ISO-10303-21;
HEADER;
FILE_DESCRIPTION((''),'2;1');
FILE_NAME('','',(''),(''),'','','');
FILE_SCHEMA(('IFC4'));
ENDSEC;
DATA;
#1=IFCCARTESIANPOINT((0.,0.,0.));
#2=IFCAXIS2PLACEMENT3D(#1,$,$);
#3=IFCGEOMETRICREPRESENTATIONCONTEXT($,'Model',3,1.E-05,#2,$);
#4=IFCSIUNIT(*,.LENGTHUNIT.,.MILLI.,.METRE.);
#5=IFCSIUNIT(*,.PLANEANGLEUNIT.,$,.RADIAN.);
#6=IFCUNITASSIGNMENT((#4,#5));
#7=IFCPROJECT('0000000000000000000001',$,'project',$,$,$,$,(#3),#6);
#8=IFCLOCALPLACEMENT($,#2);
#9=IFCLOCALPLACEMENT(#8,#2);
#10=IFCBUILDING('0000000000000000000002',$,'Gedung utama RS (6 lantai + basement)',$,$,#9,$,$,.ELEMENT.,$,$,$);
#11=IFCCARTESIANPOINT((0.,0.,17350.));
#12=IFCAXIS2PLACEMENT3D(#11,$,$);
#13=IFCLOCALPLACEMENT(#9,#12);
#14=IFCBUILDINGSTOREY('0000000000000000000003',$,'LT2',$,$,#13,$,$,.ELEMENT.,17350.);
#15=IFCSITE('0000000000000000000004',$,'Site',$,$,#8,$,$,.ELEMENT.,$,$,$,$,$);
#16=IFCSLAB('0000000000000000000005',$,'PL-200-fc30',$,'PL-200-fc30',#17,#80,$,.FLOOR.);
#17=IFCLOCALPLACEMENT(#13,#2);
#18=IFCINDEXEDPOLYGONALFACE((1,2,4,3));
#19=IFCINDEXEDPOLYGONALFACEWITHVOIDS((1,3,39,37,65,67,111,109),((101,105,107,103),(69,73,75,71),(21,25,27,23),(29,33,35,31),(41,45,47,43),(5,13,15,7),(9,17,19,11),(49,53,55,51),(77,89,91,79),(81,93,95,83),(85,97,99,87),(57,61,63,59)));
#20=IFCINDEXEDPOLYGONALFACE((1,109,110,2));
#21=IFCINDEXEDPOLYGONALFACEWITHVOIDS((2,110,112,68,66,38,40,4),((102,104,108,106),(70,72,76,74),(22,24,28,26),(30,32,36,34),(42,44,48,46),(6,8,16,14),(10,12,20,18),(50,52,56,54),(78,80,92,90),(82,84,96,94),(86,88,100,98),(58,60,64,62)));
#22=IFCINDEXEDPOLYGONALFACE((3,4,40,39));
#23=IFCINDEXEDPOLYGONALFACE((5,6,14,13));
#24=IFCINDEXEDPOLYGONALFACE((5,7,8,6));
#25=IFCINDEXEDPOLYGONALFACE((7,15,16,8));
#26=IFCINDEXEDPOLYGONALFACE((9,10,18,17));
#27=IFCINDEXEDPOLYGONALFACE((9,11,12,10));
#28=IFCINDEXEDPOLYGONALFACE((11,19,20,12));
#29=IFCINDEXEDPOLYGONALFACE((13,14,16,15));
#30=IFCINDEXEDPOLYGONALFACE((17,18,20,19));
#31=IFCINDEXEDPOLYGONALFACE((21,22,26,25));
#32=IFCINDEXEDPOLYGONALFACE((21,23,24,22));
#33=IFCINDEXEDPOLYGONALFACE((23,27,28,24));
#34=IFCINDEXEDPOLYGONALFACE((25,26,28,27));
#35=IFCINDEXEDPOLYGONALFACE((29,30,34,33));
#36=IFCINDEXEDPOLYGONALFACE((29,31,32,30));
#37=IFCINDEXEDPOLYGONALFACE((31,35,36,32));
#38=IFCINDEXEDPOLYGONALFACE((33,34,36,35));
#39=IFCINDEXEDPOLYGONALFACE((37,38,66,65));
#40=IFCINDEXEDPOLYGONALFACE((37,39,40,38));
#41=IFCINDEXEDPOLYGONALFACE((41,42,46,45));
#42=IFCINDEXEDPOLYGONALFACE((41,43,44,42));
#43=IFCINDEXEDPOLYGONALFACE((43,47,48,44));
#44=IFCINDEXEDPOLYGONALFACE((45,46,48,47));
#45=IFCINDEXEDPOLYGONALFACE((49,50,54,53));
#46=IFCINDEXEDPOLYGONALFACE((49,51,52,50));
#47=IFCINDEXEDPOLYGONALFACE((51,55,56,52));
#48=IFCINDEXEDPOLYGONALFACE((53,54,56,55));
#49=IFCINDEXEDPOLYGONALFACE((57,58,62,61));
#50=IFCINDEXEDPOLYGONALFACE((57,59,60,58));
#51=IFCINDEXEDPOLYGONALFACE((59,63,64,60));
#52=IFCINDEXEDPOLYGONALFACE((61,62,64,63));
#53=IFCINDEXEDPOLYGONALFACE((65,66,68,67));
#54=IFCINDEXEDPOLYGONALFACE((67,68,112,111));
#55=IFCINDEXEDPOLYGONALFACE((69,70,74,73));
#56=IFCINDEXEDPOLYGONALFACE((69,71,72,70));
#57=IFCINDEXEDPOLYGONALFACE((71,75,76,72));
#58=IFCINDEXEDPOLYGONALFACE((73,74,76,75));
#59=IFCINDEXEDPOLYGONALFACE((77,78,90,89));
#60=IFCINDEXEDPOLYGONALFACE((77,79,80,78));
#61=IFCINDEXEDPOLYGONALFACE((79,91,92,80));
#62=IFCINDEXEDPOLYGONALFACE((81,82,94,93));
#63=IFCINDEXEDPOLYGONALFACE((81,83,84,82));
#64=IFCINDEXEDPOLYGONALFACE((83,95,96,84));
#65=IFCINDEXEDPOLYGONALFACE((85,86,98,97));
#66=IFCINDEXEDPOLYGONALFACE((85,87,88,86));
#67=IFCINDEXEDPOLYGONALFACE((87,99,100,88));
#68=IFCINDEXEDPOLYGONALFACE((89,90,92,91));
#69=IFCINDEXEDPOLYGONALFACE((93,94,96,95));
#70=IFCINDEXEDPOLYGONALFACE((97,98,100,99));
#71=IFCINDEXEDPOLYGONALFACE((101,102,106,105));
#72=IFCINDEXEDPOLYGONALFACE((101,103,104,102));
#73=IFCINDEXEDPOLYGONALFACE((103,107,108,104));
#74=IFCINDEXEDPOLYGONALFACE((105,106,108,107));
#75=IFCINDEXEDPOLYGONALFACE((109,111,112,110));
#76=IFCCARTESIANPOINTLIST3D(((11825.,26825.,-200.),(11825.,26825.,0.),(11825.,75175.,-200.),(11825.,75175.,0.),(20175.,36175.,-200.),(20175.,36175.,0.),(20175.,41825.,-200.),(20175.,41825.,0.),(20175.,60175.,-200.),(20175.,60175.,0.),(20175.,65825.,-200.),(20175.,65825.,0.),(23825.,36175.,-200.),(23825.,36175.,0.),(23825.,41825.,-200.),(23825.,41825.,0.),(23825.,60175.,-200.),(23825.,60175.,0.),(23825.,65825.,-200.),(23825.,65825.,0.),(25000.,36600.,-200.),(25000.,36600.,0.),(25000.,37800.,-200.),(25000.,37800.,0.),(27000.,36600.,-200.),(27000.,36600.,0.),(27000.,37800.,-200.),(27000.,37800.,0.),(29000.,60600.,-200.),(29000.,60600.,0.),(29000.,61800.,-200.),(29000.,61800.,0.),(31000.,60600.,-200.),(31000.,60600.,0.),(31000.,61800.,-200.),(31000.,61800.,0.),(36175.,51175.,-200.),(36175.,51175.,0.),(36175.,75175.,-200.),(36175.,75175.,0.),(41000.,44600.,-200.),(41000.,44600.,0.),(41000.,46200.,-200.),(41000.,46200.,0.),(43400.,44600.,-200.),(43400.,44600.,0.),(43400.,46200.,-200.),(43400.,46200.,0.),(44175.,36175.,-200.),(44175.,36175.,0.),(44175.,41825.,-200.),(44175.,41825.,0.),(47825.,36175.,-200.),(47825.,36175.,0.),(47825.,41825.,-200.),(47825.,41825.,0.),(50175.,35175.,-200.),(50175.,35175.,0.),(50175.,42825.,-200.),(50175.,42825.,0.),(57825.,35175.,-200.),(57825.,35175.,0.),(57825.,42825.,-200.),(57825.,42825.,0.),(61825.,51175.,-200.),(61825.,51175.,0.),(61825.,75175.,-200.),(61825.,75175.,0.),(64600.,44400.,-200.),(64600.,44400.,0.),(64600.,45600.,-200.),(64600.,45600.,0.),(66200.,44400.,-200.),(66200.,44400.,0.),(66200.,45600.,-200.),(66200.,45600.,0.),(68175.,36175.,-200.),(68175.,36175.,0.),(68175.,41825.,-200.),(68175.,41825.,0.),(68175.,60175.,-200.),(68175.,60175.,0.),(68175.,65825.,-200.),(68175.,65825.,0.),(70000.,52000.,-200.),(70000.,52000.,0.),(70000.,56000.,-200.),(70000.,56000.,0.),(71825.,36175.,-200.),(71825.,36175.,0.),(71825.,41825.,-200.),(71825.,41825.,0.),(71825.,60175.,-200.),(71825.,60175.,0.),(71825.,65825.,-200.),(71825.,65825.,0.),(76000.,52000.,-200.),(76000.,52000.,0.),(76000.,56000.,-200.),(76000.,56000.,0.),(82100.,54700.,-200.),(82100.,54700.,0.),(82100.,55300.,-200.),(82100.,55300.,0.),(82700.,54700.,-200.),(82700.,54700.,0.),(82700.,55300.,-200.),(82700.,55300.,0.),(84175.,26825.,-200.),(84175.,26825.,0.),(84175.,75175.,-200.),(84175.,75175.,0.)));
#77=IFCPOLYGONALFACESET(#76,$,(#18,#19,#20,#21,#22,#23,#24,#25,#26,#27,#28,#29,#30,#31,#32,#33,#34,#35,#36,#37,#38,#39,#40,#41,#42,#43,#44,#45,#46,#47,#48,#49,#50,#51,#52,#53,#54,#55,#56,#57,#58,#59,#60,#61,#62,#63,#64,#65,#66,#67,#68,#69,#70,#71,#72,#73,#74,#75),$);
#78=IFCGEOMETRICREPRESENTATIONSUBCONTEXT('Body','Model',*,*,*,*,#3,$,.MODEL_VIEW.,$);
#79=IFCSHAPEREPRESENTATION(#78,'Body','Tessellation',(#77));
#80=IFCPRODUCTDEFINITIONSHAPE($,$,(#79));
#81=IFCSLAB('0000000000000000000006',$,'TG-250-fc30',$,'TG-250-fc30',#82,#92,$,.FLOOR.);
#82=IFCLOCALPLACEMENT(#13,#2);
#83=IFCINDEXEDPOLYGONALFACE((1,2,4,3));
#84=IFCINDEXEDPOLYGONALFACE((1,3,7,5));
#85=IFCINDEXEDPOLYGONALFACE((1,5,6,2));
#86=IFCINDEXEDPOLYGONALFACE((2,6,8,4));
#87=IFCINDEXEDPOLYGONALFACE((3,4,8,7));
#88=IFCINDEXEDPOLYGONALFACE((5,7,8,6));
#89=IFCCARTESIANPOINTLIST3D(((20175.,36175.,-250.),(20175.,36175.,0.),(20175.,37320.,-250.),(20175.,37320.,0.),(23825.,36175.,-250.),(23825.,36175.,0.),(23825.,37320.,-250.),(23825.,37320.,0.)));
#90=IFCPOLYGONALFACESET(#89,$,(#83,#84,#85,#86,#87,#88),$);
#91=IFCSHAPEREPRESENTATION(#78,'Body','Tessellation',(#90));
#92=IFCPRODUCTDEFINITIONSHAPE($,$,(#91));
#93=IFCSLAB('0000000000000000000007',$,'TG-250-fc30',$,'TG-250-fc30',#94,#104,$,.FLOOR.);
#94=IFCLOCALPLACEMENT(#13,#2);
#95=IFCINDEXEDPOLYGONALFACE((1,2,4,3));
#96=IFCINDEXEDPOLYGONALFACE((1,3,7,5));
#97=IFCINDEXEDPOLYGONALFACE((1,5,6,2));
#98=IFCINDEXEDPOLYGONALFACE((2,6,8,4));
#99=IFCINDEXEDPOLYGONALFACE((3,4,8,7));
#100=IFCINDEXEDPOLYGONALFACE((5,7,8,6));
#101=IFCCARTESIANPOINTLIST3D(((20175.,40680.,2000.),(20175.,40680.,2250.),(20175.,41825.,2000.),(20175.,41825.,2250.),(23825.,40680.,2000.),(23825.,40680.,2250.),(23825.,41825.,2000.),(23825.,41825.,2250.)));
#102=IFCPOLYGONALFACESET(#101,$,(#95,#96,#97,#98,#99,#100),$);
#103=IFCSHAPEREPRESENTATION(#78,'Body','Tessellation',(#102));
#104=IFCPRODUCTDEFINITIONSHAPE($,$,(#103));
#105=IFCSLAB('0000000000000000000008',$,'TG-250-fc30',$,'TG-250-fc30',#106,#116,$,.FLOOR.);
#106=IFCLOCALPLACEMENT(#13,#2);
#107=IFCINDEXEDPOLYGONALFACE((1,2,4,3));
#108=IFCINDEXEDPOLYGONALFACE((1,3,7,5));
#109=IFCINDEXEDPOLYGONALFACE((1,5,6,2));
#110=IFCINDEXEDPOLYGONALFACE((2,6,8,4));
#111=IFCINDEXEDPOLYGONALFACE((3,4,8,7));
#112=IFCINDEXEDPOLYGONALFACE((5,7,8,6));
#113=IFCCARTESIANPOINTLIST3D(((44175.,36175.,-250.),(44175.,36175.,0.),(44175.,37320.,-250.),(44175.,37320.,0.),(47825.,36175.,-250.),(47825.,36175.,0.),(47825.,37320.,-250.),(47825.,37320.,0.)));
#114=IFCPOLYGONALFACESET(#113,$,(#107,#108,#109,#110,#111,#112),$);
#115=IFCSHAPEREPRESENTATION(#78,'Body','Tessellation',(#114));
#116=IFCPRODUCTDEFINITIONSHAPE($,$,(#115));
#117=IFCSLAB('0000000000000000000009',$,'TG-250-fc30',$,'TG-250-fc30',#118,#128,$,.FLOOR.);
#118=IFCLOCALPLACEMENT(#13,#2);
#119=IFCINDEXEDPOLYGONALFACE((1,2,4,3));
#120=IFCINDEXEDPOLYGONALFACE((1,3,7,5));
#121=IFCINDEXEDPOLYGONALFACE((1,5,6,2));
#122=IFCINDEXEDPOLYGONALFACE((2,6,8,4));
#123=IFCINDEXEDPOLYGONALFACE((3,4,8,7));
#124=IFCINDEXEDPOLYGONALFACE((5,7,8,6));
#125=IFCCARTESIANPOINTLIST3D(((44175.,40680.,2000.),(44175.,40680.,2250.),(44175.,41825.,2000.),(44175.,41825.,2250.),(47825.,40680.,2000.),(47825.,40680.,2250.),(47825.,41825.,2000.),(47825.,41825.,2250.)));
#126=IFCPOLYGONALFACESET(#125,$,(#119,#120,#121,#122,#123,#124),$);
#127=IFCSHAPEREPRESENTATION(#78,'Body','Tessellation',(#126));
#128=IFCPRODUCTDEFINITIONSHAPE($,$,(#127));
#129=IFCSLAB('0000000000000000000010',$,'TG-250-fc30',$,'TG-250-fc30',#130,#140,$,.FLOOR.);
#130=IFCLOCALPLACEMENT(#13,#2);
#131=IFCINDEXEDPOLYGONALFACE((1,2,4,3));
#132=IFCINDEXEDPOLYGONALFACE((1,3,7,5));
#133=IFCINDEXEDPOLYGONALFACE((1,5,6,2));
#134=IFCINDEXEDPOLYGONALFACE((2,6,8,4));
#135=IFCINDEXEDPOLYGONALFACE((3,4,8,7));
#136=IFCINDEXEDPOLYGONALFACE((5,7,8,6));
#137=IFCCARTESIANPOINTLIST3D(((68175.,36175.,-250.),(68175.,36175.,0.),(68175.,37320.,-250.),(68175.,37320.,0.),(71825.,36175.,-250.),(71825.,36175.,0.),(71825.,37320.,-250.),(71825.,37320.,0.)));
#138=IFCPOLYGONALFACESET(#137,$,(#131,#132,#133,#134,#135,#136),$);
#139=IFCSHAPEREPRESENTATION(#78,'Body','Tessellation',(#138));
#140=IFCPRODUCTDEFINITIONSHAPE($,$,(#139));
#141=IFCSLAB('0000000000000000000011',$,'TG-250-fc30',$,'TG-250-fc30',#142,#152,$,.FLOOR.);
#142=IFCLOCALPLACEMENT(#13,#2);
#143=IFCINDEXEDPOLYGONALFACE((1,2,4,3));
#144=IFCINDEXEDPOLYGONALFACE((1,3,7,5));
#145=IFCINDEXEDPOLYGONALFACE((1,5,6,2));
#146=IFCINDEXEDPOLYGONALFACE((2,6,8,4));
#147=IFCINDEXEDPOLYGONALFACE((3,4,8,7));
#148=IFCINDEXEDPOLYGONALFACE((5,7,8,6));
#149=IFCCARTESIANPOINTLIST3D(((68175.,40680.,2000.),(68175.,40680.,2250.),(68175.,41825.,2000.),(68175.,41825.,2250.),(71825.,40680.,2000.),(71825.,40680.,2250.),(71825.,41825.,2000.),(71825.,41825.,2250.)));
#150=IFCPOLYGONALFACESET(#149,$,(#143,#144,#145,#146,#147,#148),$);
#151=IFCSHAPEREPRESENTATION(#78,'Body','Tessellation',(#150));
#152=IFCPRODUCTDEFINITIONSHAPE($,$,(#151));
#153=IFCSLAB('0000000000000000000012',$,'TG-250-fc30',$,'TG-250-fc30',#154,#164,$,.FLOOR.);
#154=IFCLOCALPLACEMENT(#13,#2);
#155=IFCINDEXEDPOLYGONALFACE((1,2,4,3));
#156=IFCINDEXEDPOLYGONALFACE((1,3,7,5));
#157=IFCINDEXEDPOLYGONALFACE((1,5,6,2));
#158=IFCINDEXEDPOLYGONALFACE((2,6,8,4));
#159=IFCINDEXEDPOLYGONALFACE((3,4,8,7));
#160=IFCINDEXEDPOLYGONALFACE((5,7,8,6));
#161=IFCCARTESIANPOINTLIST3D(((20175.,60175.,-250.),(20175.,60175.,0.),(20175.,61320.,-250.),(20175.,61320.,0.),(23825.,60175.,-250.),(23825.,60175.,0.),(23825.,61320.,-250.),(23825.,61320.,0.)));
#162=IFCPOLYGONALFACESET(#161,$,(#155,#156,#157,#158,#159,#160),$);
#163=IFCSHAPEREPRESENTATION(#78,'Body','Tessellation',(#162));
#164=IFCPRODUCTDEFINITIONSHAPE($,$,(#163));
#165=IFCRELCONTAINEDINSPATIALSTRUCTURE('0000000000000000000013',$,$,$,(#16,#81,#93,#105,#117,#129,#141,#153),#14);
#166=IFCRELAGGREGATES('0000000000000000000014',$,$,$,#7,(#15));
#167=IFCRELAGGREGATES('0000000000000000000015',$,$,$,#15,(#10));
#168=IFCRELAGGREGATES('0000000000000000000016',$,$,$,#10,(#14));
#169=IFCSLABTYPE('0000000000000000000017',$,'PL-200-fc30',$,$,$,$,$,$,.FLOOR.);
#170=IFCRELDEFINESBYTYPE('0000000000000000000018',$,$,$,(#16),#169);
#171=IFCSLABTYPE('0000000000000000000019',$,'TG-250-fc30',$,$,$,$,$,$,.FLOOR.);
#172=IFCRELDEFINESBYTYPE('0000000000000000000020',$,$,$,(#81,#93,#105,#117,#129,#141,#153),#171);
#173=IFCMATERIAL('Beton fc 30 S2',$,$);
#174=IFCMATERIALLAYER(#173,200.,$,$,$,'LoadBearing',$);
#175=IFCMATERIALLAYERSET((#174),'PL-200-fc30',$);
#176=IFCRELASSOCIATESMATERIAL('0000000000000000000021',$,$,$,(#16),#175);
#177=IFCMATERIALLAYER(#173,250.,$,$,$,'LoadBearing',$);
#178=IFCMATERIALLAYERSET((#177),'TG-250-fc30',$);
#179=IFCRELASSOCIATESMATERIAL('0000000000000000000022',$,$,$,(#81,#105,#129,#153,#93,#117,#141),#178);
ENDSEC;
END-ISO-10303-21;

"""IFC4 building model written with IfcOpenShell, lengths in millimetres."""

from ifc_helpers import new_model, si_unit, frame, origin, place, context, subcontext, project, spatial, polyline, outline, extrude, material, layer, layer_set, layer_usage, type_object, element, save


model = new_model("IFC4")

# Units and contexts
model_context = context("Model", 3, precision=1e-05, world=origin())
body_context = subcontext(model_context, "Body", "Model", "MODEL_VIEW")
ifc_project = project(units=[si_unit("LENGTHUNIT", "METRE", prefix="MILLI"), si_unit("PLANEANGLEUNIT", "RADIAN")], contexts=[model_context])

# Site, building, storey
site_placement = place(None, origin())
site = spatial("IfcSite", under=ifc_project, at=site_placement, Name="Site", CompositionType="ELEMENT")
building_placement = place(site_placement, origin())
building = spatial("IfcBuilding", under=site, at=building_placement, Name="Gedung utama RS (6 lantai + basement)", CompositionType="ELEMENT")
storey_placement = place(building_placement, frame((0.0, 0.0, 17350.0)))
storey = spatial("IfcBuildingStorey", under=building, at=storey_placement, Name="LT2", CompositionType="ELEMENT", Elevation=17350.0)

# Shared definitions
ifc_material_1 = material(Name="Beton fc 30 S2")

# Shared definitions
ifc_layer_1 = layer(ifc_material_1, 200.0, Category="LoadBearing")
ifc_layer_set_1 = layer_set([ifc_layer_1], Name="PL-200-fc30")
slab_type_1 = type_object("IfcSlabType", Name="PL-200-fc30", PredefinedType="FLOOR")

# Slab, openings
ifc_layer_usage_1 = layer_usage(ifc_layer_set_1, "AXIS3", "NEGATIVE", 0.0)
slab_1_placement = place(storey_placement, origin())
slab_1 = element("IfcSlab", 1, at=slab_1_placement, inside=storey, type_object=slab_type_1, material=ifc_layer_usage_1, Name="PL-200-fc30", ObjectType="PL-200-fc30", PredefinedType="FLOOR", context=body_context, shape_type="SweptSolid", body=[
    extrude(outline(polyline([(61825.0, 75175.0), (61825.0, 51175.0), (36175.0, 51175.0), (36175.0, 75175.0), (11825.0, 75175.0), (11825.0, 26825.0), (84175.0, 26825.0), (84175.0, 75175.0), (61825.0, 75175.0)]), holes=[polyline([(23825.0, 36175.0), (23825.0, 41825.0), (20175.0, 41825.0), (20175.0, 36175.0), (23825.0, 36175.0)]), polyline([(47825.0, 36175.0), (47825.0, 41825.0), (44175.0, 41825.0), (44175.0, 36175.0), (47825.0, 36175.0)]), polyline([(71825.0, 36175.0), (71825.0, 41825.0), (68175.0, 41825.0), (68175.0, 36175.0), (71825.0, 36175.0)]), polyline([(23825.0, 60175.0), (23825.0, 65825.0), (20175.0, 65825.0), (20175.0, 60175.0), (23825.0, 60175.0)]), polyline([(71825.0, 60175.0), (71825.0, 65825.0), (68175.0, 65825.0), (68175.0, 60175.0), (71825.0, 60175.0)]), polyline([(76000.0, 52000.0), (76000.0, 56000.0), (70000.0, 56000.0), (70000.0, 52000.0), (76000.0, 52000.0)])]), frame((0.0, 0.0, -200.0)), (0.0, 0.0, 1.0), 200.0),
])
opening_1_placement = place(slab_1_placement, frame((0.0, 0.0, -4400.0)))
element("IfcOpeningElement", 2, at=opening_1_placement, cuts=slab_1, PredefinedType="OPENING", context=body_context, shape_type="SweptSolid", body=[
    extrude(outline(polyline([(27000.0, 36600.0), (27000.0, 37800.0), (25000.0, 37800.0), (25000.0, 36600.0), (27000.0, 36600.0)])), origin(), (0.0, 0.0, 1.0), 25800.0),
])
opening_2_placement = place(slab_1_placement, frame((0.0, 0.0, -4400.0)))
element("IfcOpeningElement", 3, at=opening_2_placement, cuts=slab_1, PredefinedType="OPENING", context=body_context, shape_type="SweptSolid", body=[
    extrude(outline(polyline([(43400.0, 44600.0), (43400.0, 46200.0), (41000.0, 46200.0), (41000.0, 44600.0), (43400.0, 44600.0)])), origin(), (0.0, 0.0, 1.0), 25800.0),
])
opening_3_placement = place(slab_1_placement, frame((0.0, 0.0, -4400.0)))
element("IfcOpeningElement", 4, at=opening_3_placement, cuts=slab_1, PredefinedType="OPENING", context=body_context, shape_type="SweptSolid", body=[
    extrude(outline(polyline([(66200.0, 44400.0), (66200.0, 45600.0), (64600.0, 45600.0), (64600.0, 44400.0), (66200.0, 44400.0)])), origin(), (0.0, 0.0, 1.0), 25800.0),
])
opening_4_placement = place(slab_1_placement, frame((0.0, 0.0, -4400.0)))
element("IfcOpeningElement", 5, at=opening_4_placement, cuts=slab_1, PredefinedType="OPENING", context=body_context, shape_type="SweptSolid", body=[
    extrude(outline(polyline([(31000.0, 60600.0), (31000.0, 61800.0), (29000.0, 61800.0), (29000.0, 60600.0), (31000.0, 60600.0)])), origin(), (0.0, 0.0, 1.0), 13200.0),
])
opening_5_placement = place(slab_1_placement, frame((0.0, 0.0, -4400.0)))
element("IfcOpeningElement", 6, at=opening_5_placement, cuts=slab_1, PredefinedType="OPENING", context=body_context, shape_type="SweptSolid", body=[
    extrude(outline(polyline([(82700.0, 54700.0), (82700.0, 55300.0), (82100.0, 55300.0), (82100.0, 54700.0), (82700.0, 54700.0)])), origin(), (0.0, 0.0, 1.0), 9000.0),
])
opening_6_placement = place(slab_1_placement, frame((0.0, 0.0, -4400.0)))
element("IfcOpeningElement", 7, at=opening_6_placement, cuts=slab_1, PredefinedType="OPENING", context=body_context, shape_type="SweptSolid", body=[
    extrude(outline(polyline([(57825.0, 35175.0), (57825.0, 42825.0), (50175.0, 42825.0), (50175.0, 35175.0), (57825.0, 35175.0)])), origin(), (0.0, 0.0, 1.0), 21600.0),
])

# Slabs
ifc_layer_2 = layer(ifc_material_1, 250.0, Category="LoadBearing")
ifc_layer_set_2 = layer_set([ifc_layer_2], Name="TG-250-fc30")
ifc_layer_usage_2 = layer_usage(ifc_layer_set_2, "AXIS3", "NEGATIVE", 0.0)
slab_type_2 = type_object("IfcSlabType", Name="TG-250-fc30", PredefinedType="FLOOR")
slab_2_placement = place(storey_placement, origin())
element("IfcSlab", 8, at=slab_2_placement, inside=storey, type_object=slab_type_2, material=ifc_layer_usage_2, Name="TG-250-fc30", ObjectType="TG-250-fc30", PredefinedType="FLOOR", context=body_context, shape_type="SweptSolid", body=[
    extrude(outline(polyline([(23825.0, 36175.0), (23825.0, 37320.0), (20175.0, 37320.0), (20175.0, 36175.0), (23825.0, 36175.0)])), frame((0.0, 0.0, -250.0)), (0.0, 0.0, 1.0), 250.0),
])
ifc_layer_usage_3 = layer_usage(ifc_layer_set_2, "AXIS3", "NEGATIVE", 2250.0)
slab_3_placement = place(storey_placement, origin())
element("IfcSlab", 9, at=slab_3_placement, inside=storey, type_object=slab_type_2, material=ifc_layer_usage_3, Name="TG-250-fc30", ObjectType="TG-250-fc30", PredefinedType="FLOOR", context=body_context, shape_type="SweptSolid", body=[
    extrude(outline(polyline([(23825.0, 40680.0), (23825.0, 41825.0), (20175.0, 41825.0), (20175.0, 40680.0), (23825.0, 40680.0)])), frame((0.0, 0.0, 2000.0)), (0.0, 0.0, 1.0), 250.0),
])
slab_4_placement = place(storey_placement, origin())
element("IfcSlab", 10, at=slab_4_placement, inside=storey, type_object=slab_type_2, material=ifc_layer_usage_2, Name="TG-250-fc30", ObjectType="TG-250-fc30", PredefinedType="FLOOR", context=body_context, shape_type="SweptSolid", body=[
    extrude(outline(polyline([(47825.0, 36175.0), (47825.0, 37320.0), (44175.0, 37320.0), (44175.0, 36175.0), (47825.0, 36175.0)])), frame((0.0, 0.0, -250.0)), (0.0, 0.0, 1.0), 250.0),
])
slab_5_placement = place(storey_placement, origin())
element("IfcSlab", 11, at=slab_5_placement, inside=storey, type_object=slab_type_2, material=ifc_layer_usage_3, Name="TG-250-fc30", ObjectType="TG-250-fc30", PredefinedType="FLOOR", context=body_context, shape_type="SweptSolid", body=[
    extrude(outline(polyline([(47825.0, 40680.0), (47825.0, 41825.0), (44175.0, 41825.0), (44175.0, 40680.0), (47825.0, 40680.0)])), frame((0.0, 0.0, 2000.0)), (0.0, 0.0, 1.0), 250.0),
])
slab_6_placement = place(storey_placement, origin())
element("IfcSlab", 12, at=slab_6_placement, inside=storey, type_object=slab_type_2, material=ifc_layer_usage_2, Name="TG-250-fc30", ObjectType="TG-250-fc30", PredefinedType="FLOOR", context=body_context, shape_type="SweptSolid", body=[
    extrude(outline(polyline([(71825.0, 36175.0), (71825.0, 37320.0), (68175.0, 37320.0), (68175.0, 36175.0), (71825.0, 36175.0)])), frame((0.0, 0.0, -250.0)), (0.0, 0.0, 1.0), 250.0),
])
slab_7_placement = place(storey_placement, origin())
element("IfcSlab", 13, at=slab_7_placement, inside=storey, type_object=slab_type_2, material=ifc_layer_usage_3, Name="TG-250-fc30", ObjectType="TG-250-fc30", PredefinedType="FLOOR", context=body_context, shape_type="SweptSolid", body=[
    extrude(outline(polyline([(71825.0, 40680.0), (71825.0, 41825.0), (68175.0, 41825.0), (68175.0, 40680.0), (71825.0, 40680.0)])), frame((0.0, 0.0, 2000.0)), (0.0, 0.0, 1.0), 250.0),
])
slab_8_placement = place(storey_placement, origin())
element("IfcSlab", 14, at=slab_8_placement, inside=storey, type_object=slab_type_2, material=ifc_layer_usage_2, Name="TG-250-fc30", ObjectType="TG-250-fc30", PredefinedType="FLOOR", context=body_context, shape_type="SweptSolid", body=[
    extrude(outline(polyline([(23825.0, 60175.0), (23825.0, 61320.0), (20175.0, 61320.0), (20175.0, 60175.0), (23825.0, 60175.0)])), frame((0.0, 0.0, -250.0)), (0.0, 0.0, 1.0), 250.0),
])

save(model, "model.ifc")
